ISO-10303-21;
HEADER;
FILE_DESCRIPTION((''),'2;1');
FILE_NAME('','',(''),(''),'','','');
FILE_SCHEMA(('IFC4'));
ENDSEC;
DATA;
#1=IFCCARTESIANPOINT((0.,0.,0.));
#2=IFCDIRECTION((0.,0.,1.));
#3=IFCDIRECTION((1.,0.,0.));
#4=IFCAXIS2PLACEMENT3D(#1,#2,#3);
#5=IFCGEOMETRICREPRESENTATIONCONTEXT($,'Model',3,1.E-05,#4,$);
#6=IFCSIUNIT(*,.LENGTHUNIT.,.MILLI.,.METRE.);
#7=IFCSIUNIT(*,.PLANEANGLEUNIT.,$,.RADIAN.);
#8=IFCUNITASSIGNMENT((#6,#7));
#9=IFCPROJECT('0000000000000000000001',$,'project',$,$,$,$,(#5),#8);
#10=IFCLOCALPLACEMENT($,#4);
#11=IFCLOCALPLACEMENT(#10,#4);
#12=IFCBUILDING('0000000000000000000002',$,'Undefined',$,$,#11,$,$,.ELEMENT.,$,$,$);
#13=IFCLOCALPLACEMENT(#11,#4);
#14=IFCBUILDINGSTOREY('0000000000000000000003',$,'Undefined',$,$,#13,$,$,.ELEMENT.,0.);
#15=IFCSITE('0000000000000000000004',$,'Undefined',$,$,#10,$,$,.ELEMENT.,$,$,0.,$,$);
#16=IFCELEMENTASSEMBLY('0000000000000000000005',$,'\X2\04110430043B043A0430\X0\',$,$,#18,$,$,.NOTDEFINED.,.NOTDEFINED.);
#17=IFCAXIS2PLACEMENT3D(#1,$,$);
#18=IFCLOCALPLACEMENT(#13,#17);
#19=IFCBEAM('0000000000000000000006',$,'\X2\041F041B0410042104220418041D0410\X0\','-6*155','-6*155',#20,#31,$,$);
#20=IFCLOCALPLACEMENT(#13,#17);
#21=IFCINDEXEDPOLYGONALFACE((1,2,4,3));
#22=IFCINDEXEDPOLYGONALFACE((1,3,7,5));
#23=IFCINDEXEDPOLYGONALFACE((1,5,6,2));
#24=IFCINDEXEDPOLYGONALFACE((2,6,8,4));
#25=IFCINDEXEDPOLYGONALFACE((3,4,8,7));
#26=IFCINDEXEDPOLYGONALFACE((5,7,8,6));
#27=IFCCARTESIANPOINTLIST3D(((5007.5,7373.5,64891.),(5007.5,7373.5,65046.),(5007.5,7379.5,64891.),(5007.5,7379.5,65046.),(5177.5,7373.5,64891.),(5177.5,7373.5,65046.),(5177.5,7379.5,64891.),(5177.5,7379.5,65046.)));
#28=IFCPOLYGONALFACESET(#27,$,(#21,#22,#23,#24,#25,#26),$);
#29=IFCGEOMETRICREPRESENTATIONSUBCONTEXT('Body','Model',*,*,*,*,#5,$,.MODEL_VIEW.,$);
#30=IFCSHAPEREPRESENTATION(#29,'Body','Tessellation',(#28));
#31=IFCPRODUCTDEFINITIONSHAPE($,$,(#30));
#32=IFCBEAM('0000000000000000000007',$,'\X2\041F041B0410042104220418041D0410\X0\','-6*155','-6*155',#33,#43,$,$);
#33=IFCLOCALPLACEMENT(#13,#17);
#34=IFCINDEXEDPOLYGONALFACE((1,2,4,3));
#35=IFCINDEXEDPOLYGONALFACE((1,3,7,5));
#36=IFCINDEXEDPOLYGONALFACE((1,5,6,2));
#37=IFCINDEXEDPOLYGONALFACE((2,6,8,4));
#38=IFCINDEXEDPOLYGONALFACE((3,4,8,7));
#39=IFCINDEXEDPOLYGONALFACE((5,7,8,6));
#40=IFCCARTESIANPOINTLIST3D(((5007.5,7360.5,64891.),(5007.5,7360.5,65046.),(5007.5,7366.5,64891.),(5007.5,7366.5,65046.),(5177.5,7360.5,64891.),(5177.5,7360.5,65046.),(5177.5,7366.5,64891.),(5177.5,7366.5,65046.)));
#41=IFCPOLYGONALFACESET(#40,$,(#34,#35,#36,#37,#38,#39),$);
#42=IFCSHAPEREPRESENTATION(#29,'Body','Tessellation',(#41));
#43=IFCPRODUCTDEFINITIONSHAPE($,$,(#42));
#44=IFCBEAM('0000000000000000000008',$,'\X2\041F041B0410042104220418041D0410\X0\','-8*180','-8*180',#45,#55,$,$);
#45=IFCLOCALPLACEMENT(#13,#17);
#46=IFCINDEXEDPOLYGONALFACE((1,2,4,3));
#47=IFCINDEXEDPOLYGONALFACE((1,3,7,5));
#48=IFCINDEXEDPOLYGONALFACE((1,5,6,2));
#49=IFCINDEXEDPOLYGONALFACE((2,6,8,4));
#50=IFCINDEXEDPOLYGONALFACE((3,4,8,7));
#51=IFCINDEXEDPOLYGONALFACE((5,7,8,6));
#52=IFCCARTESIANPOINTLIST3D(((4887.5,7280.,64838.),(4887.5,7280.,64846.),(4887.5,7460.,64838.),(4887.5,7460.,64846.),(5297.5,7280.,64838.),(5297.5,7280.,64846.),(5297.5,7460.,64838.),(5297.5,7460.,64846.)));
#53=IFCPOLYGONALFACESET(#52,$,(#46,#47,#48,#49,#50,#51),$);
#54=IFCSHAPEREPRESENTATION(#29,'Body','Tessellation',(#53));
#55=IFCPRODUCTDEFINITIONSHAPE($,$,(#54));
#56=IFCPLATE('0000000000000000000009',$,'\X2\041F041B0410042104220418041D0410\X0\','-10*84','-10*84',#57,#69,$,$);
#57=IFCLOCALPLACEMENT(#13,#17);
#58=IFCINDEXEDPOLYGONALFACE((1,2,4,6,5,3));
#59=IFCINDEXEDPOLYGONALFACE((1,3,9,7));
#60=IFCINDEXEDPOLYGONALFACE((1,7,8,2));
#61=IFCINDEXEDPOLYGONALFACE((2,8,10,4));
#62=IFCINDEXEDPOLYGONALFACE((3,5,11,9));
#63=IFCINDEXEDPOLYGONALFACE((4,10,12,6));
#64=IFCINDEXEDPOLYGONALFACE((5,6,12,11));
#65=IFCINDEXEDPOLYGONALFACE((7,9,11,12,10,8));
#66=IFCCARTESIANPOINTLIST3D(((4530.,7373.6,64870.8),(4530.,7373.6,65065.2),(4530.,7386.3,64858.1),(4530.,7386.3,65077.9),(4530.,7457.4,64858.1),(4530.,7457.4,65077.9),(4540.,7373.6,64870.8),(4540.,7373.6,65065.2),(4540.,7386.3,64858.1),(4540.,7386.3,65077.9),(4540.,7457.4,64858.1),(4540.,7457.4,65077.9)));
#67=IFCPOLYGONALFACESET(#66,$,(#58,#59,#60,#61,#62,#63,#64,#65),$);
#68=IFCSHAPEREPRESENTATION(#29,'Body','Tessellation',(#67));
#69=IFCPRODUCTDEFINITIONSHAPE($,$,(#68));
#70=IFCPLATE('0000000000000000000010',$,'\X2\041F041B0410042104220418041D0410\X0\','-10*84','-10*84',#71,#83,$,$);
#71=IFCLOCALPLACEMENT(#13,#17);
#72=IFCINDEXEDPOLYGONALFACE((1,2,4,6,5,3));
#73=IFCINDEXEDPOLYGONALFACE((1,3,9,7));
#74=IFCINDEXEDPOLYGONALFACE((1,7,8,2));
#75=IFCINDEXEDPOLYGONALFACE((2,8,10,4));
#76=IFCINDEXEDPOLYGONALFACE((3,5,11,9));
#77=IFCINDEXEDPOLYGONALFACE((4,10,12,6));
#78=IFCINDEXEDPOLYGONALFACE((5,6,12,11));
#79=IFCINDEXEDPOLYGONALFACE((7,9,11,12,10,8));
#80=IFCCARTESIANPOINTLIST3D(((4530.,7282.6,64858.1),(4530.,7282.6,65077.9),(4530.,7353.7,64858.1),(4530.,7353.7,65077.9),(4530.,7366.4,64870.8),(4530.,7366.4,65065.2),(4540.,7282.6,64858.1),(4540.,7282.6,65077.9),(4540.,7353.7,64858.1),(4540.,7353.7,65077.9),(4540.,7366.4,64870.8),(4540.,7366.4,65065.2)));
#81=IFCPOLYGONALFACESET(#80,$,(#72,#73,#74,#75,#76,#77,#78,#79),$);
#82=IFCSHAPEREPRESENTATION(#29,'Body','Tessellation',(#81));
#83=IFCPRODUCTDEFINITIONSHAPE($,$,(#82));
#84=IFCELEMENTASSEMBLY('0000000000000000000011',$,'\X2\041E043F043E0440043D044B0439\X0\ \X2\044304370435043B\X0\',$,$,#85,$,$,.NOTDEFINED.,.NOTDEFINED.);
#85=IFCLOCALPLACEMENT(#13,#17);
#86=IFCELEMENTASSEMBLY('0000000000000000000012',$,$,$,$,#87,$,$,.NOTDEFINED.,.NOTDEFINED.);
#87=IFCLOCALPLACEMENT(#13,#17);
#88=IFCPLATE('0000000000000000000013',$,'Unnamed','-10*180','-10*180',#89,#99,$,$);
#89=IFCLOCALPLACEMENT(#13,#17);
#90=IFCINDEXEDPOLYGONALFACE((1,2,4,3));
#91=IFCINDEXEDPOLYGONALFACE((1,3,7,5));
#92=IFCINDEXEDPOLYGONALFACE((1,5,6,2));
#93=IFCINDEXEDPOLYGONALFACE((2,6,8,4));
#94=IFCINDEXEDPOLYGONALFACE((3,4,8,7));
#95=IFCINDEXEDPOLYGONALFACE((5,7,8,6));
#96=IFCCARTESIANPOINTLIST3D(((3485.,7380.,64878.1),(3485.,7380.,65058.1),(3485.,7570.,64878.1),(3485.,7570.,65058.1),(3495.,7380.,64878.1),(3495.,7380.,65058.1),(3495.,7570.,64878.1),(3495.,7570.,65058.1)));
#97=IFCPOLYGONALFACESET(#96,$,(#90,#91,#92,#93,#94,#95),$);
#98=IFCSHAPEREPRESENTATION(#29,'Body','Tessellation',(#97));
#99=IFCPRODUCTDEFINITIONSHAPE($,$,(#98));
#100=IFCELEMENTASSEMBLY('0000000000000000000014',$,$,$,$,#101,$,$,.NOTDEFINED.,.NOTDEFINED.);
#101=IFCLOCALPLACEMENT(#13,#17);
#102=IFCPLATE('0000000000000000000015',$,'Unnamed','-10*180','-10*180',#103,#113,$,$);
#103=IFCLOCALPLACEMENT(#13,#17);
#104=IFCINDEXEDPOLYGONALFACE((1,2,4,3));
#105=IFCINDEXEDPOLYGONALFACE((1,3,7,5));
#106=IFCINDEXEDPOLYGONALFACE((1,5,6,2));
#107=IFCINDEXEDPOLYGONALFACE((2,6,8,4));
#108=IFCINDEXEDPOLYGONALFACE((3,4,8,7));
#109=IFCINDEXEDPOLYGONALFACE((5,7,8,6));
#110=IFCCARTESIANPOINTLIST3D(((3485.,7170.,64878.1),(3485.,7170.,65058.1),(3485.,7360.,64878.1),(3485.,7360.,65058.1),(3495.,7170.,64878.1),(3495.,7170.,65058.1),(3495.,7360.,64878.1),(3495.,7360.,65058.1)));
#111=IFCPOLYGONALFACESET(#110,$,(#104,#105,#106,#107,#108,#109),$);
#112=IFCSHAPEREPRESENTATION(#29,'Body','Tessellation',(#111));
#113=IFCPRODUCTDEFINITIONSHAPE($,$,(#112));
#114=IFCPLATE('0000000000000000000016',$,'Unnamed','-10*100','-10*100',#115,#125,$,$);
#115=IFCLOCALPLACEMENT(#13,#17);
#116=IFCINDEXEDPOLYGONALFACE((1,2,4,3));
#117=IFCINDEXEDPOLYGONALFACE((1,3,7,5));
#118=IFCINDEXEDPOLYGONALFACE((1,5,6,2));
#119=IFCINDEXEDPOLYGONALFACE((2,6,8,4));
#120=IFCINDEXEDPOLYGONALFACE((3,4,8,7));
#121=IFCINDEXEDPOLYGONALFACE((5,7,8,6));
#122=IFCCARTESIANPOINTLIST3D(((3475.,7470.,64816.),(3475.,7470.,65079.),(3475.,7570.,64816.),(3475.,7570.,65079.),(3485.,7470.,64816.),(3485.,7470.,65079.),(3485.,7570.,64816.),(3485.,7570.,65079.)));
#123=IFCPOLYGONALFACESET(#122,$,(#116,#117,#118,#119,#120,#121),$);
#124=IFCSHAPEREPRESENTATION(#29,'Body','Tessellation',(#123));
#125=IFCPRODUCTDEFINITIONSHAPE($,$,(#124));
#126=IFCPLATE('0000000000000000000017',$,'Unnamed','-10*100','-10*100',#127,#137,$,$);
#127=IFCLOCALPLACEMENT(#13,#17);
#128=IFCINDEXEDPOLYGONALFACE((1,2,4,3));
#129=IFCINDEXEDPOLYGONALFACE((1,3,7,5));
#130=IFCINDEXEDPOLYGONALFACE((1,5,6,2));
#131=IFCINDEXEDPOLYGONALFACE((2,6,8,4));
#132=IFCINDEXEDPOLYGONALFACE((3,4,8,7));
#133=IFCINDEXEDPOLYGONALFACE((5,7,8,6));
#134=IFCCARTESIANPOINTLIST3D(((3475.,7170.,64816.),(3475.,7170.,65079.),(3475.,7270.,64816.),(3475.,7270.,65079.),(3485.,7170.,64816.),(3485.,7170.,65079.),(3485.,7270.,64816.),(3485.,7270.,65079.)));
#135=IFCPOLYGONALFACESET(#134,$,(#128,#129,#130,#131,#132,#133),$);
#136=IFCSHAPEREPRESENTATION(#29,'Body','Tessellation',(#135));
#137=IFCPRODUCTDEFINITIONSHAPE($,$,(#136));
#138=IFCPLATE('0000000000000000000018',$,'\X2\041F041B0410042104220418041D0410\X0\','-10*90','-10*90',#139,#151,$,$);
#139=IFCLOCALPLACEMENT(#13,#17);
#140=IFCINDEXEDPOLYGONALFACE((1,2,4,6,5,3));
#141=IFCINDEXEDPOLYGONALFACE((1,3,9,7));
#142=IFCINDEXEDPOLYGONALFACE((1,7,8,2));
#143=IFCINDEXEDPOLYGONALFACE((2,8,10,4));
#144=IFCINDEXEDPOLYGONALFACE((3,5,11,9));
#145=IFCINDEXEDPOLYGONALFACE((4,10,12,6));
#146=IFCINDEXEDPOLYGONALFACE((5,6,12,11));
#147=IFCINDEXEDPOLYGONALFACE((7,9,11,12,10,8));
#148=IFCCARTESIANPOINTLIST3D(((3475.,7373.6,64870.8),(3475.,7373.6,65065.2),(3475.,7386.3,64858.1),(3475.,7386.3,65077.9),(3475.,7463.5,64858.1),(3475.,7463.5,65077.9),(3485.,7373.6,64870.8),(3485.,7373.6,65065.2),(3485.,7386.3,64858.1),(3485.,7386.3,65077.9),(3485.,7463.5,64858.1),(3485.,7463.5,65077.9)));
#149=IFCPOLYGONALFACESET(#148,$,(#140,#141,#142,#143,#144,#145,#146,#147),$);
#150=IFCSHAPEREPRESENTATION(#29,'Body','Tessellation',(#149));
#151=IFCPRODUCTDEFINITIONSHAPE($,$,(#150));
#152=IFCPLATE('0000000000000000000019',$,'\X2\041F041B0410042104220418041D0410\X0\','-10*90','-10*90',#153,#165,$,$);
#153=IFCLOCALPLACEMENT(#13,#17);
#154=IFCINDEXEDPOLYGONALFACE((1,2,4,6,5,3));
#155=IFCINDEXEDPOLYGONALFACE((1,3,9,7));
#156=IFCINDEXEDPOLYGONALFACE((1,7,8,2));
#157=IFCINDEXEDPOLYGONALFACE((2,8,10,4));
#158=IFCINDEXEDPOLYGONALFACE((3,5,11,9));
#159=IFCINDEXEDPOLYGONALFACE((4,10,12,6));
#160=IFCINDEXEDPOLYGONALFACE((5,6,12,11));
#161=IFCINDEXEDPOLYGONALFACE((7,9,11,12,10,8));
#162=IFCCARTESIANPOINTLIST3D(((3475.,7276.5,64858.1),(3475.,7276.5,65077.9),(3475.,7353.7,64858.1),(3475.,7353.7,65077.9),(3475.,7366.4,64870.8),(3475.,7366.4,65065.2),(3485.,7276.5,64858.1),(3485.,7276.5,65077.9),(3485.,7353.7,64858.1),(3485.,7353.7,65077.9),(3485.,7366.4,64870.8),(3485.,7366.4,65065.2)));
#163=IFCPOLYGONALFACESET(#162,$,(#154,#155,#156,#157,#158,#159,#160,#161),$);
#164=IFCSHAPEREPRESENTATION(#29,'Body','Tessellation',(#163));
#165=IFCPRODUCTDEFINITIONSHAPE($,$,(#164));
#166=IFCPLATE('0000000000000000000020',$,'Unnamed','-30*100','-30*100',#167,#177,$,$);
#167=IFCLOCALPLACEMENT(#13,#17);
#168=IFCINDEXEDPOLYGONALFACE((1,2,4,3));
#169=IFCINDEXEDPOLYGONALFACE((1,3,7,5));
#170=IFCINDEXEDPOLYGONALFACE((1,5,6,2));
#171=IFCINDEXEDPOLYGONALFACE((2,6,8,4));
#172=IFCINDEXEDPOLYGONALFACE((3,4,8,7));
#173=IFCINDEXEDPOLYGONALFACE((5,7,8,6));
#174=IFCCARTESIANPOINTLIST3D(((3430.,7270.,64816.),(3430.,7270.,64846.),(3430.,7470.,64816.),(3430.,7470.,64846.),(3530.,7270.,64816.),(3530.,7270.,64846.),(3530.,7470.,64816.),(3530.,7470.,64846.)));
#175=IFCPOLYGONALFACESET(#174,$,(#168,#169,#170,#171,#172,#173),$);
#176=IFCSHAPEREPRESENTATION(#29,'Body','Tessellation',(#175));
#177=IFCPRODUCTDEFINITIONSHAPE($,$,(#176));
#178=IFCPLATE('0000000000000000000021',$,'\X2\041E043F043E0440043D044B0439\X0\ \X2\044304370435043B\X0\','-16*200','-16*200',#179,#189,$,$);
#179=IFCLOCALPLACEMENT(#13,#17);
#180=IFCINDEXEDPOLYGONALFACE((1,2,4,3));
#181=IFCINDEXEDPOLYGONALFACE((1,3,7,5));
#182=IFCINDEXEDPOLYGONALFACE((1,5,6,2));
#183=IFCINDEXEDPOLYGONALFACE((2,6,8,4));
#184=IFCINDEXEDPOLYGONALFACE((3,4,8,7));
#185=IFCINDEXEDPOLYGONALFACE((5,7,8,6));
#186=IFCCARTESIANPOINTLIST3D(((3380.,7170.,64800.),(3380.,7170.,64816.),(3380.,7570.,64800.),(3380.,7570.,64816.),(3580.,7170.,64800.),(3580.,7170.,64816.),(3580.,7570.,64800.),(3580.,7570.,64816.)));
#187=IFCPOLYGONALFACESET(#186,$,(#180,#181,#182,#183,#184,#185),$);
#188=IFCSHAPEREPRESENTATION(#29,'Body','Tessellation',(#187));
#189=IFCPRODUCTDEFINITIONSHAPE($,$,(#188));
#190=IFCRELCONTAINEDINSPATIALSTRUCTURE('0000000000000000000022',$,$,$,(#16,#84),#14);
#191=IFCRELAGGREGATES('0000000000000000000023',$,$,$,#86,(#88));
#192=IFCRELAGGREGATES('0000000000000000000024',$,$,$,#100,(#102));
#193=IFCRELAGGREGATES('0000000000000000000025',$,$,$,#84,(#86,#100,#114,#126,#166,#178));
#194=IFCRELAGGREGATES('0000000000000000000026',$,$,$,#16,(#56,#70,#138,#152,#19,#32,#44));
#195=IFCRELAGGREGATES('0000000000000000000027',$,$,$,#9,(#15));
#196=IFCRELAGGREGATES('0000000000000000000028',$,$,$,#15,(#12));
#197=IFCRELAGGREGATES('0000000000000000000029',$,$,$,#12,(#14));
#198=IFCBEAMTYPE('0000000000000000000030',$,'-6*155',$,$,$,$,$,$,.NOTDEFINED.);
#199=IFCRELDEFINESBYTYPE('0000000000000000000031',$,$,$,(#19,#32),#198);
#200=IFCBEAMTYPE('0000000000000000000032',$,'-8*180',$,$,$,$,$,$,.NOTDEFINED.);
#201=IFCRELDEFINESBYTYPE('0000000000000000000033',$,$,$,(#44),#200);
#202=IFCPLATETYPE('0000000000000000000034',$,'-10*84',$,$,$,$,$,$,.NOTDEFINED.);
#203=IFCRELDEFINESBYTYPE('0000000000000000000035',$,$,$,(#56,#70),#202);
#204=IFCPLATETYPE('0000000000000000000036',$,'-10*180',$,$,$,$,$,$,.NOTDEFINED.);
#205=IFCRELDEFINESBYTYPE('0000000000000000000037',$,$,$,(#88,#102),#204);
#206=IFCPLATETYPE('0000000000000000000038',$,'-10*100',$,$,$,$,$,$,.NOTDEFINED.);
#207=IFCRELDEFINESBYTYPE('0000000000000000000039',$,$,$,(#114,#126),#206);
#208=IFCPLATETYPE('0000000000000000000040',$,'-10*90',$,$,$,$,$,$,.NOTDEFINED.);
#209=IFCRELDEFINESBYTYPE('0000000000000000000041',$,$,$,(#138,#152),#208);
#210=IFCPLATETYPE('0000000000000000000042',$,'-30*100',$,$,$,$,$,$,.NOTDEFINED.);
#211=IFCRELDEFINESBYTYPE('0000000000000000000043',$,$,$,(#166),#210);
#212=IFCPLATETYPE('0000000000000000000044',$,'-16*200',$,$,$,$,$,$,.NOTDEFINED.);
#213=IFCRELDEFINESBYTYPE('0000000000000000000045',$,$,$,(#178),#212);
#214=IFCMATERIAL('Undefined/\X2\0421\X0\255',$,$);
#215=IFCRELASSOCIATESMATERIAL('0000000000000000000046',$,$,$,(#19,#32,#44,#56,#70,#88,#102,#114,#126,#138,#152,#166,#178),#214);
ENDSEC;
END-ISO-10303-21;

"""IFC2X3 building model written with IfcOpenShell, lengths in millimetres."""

from ifc_helpers import new_model, si_unit, frame, origin_with_axes, origin_2d_with_axis, place, context, subcontext, project, spatial, polyline, rectangle, outline, extrude, material, type_object, element, aggregate, save


model = new_model("IFC2X3")

# Units and contexts
model_context = context("Model", 3, precision=1e-05, world=origin_with_axes())
body_context = subcontext(model_context, "Body", "Model", "MODEL_VIEW")
ifc_project = project(units=[si_unit("LENGTHUNIT", "METRE", prefix="MILLI"), si_unit("PLANEANGLEUNIT", "RADIAN")], contexts=[model_context])

# Site, building, storey
site_placement = place(None, origin_with_axes())
site = spatial("IfcSite", under=ifc_project, at=site_placement, Name="Undefined", CompositionType="ELEMENT", RefElevation=0.0)
building_placement = place(site_placement, origin_with_axes())
building = spatial("IfcBuilding", under=site, at=building_placement, Name="Undefined", CompositionType="ELEMENT")
storey_placement = place(building_placement, origin_with_axes())
storey = spatial("IfcBuildingStorey", under=building, at=storey_placement, Name="Undefined", CompositionType="ELEMENT", Elevation=0.0)

# Element assembly, beams, plates
assembly_1_placement = place(storey_placement, origin_with_axes())
assembly_1 = element("IfcElementAssembly", 1, at=assembly_1_placement, inside=storey, Name="Балка", AssemblyPlace="NOTDEFINED", PredefinedType="NOTDEFINED")
ifc_material_1 = material(Name="Undefined/С255")
beam_type_1 = type_object("IfcBeamType", Name="-6*155", PredefinedType="NOTDEFINED")
beam_1_placement = place(assembly_1_placement, frame((5007.5, 7376.5, 64968.5), z_axis=(0.0, 0.0, 1.0), x_axis=(1.0, 0.0, 0.0)))
beam_1 = element("IfcBeam", 2, at=beam_1_placement, type_object=beam_type_1, material=ifc_material_1, Name="ПЛАСТИНА", Description="-6*155", ObjectType="-6*155", context=body_context, shape_type="SweptSolid", body=[
    extrude(rectangle(XDim=6.0, YDim=155.0, at=origin_2d_with_axis()), frame((170.0, 0.0, 0.0), z_axis=(-1.0, 0.0, 0.0), x_axis=(0.0, -1.0, 0.0)), (0.0, 0.0, 1.0), 170.0),
])
beam_2_placement = place(assembly_1_placement, frame((5007.5, 7363.5, 64968.5), z_axis=(0.0, 0.0, 1.0), x_axis=(1.0, 0.0, 0.0)))
beam_2 = element("IfcBeam", 3, at=beam_2_placement, type_object=beam_type_1, material=ifc_material_1, Name="ПЛАСТИНА", Description="-6*155", ObjectType="-6*155", context=body_context, shape_type="SweptSolid", body=[
    extrude(rectangle(XDim=6.0, YDim=155.0, at=origin_2d_with_axis()), frame((170.0, 0.0, 0.0), z_axis=(-1.0, 0.0, 0.0), x_axis=(0.0, -1.0, 0.0)), (0.0, 0.0, 1.0), 170.0),
])
beam_type_2 = type_object("IfcBeamType", Name="-8*180", PredefinedType="NOTDEFINED")
beam_3_placement = place(assembly_1_placement, frame((4887.5, 7370.0, 64842.0), z_axis=(0.0, -1.0, 0.0), x_axis=(1.0, 0.0, 0.0)))
beam_3 = element("IfcBeam", 4, at=beam_3_placement, type_object=beam_type_2, material=ifc_material_1, Name="ПЛАСТИНА", Description="-8*180", ObjectType="-8*180", context=body_context, shape_type="SweptSolid", body=[
    extrude(rectangle(XDim=8.0, YDim=180.0, at=origin_2d_with_axis()), frame((410.0, 0.0, 0.0), z_axis=(-1.0, 0.0, 0.0), x_axis=(0.0, -1.0, 0.0)), (0.0, 0.0, 1.0), 410.0),
])
plate_type_1 = type_object("IfcPlateType", Name="-10*84", PredefinedType="NOTDEFINED")
plate_1_placement = place(assembly_1_placement, frame((4535.0, 7373.6, 65077.9), z_axis=(-1.0, 0.0, 0.0), x_axis=(0.0, 1.0, 0.0)))
plate_1 = element("IfcPlate", 5, at=plate_1_placement, type_object=plate_type_1, material=ifc_material_1, Name="ПЛАСТИНА", Description="-10*84", ObjectType="-10*84", context=body_context, shape_type="SweptSolid", body=[
    extrude(outline(polyline([(0.0, 12.7), (12.7, 0.0), (83.8, 0.0), (83.8, 219.8), (12.7, 219.8), (0.0, 207.1), (0.0, 12.7)])), frame((0.0, 0.0, -5.0), z_axis=(0.0, 0.0, 1.0), x_axis=(1.0, 0.0, 0.0)), (0.0, 0.0, 1.0), 10.0),
])
plate_2_placement = place(assembly_1_placement, frame((4535.0, 7282.6, 65077.9), z_axis=(-1.0, 0.0, 0.0), x_axis=(0.0, 1.0, 0.0)))
plate_2 = element("IfcPlate", 6, at=plate_2_placement, type_object=plate_type_1, material=ifc_material_1, Name="ПЛАСТИНА", Description="-10*84", ObjectType="-10*84", context=body_context, shape_type="SweptSolid", body=[
    extrude(outline(polyline([(0.0, 0.0), (71.1, 0.0), (83.8, 12.7), (83.8, 207.1), (71.1, 219.8), (0.0, 219.8), (0.0, 0.0)])), frame((0.0, 0.0, -5.0), z_axis=(0.0, 0.0, 1.0), x_axis=(1.0, 0.0, 0.0)), (0.0, 0.0, 1.0), 10.0),
])

# Element assemblies, plates
assembly_2_placement = place(storey_placement, origin_with_axes())
assembly_2 = element("IfcElementAssembly", 7, at=assembly_2_placement, inside=storey, Name="Опорный узел", AssemblyPlace="NOTDEFINED", PredefinedType="NOTDEFINED")
assembly_3_placement = place(assembly_2_placement, origin_with_axes())
assembly_3 = element("IfcElementAssembly", 8, at=assembly_3_placement, AssemblyPlace="NOTDEFINED", PredefinedType="NOTDEFINED")
plate_type_2 = type_object("IfcPlateType", Name="-10*180", PredefinedType="NOTDEFINED")
plate_3_placement = place(assembly_3_placement, frame((3490.0, 7570.0, 65058.1), z_axis=(1.0, 0.0, 0.0), x_axis=(0.0, -1.0, 0.0)))
plate_3 = element("IfcPlate", 9, at=plate_3_placement, type_object=plate_type_2, material=ifc_material_1, Name="Unnamed", Description="-10*180", ObjectType="-10*180", context=body_context, shape_type="SweptSolid", body=[
    extrude(outline(polyline([(0.0, 0.0), (190.0, 0.0), (190.0, 180.0), (0.0, 180.0), (0.0, 0.0)])), frame((0.0, 0.0, -5.0), z_axis=(0.0, 0.0, 1.0), x_axis=(1.0, 0.0, 0.0)), (0.0, 0.0, 1.0), 10.0),
])
aggregate(assembly_3, [plate_3])
assembly_4_placement = place(assembly_2_placement, origin_with_axes())
assembly_4 = element("IfcElementAssembly", 10, at=assembly_4_placement, AssemblyPlace="NOTDEFINED", PredefinedType="NOTDEFINED")
plate_4_placement = place(assembly_4_placement, frame((3490.0, 7360.0, 65058.1), z_axis=(1.0, 0.0, 0.0), x_axis=(0.0, -1.0, 0.0)))
plate_4 = element("IfcPlate", 11, at=plate_4_placement, type_object=plate_type_2, material=ifc_material_1, Name="Unnamed", Description="-10*180", ObjectType="-10*180", context=body_context, shape_type="SweptSolid", body=[
    extrude(outline(polyline([(0.0, 0.0), (190.0, 0.0), (190.0, 180.0), (0.0, 180.0), (0.0, 0.0)])), frame((0.0, 0.0, -5.0), z_axis=(0.0, 0.0, 1.0), x_axis=(1.0, 0.0, 0.0)), (0.0, 0.0, 1.0), 10.0),
])
aggregate(assembly_4, [plate_4])
plate_type_3 = type_object("IfcPlateType", Name="-10*100", PredefinedType="NOTDEFINED")
plate_5_placement = place(assembly_2_placement, frame((3480.0, 7470.0, 64816.0), z_axis=(-1.0, 0.0, 0.0), x_axis=(0.0, 0.0, 1.0)))
plate_5 = element("IfcPlate", 12, at=plate_5_placement, type_object=plate_type_3, material=ifc_material_1, Name="Unnamed", Description="-10*100", ObjectType="-10*100", context=body_context, shape_type="SweptSolid", body=[
    extrude(outline(polyline([(0.0, 0.0), (263.0, 0.0), (263.0, 100.0), (0.0, 100.0), (0.0, 0.0)])), frame((0.0, 0.0, -5.0), z_axis=(0.0, 0.0, 1.0), x_axis=(1.0, 0.0, 0.0)), (0.0, 0.0, 1.0), 10.0),
])
plate_6_placement = place(assembly_2_placement, frame((3480.0, 7170.0, 64816.0), z_axis=(-1.0, 0.0, 0.0), x_axis=(0.0, 0.0, 1.0)))
plate_6 = element("IfcPlate", 13, at=plate_6_placement, type_object=plate_type_3, material=ifc_material_1, Name="Unnamed", Description="-10*100", ObjectType="-10*100", context=body_context, shape_type="SweptSolid", body=[
    extrude(outline(polyline([(0.0, 0.0), (263.0, 0.0), (263.0, 100.0), (0.0, 100.0), (0.0, 0.0)])), frame((0.0, 0.0, -5.0), z_axis=(0.0, 0.0, 1.0), x_axis=(1.0, 0.0, 0.0)), (0.0, 0.0, 1.0), 10.0),
])

# Plates
plate_type_4 = type_object("IfcPlateType", Name="-10*90", PredefinedType="NOTDEFINED")
plate_7_placement = place(assembly_1_placement, frame((3480.0, 7373.6, 65077.9), z_axis=(-1.0, 0.0, 0.0), x_axis=(0.0, 1.0, 0.0)))
plate_7 = element("IfcPlate", 14, at=plate_7_placement, type_object=plate_type_4, material=ifc_material_1, Name="ПЛАСТИНА", Description="-10*90", ObjectType="-10*90", context=body_context, shape_type="SweptSolid", body=[
    extrude(outline(polyline([(0.0, 12.7), (12.7, 0.0), (89.9, 0.0), (89.9, 219.8), (12.7, 219.8), (0.0, 207.1), (0.0, 12.7)])), frame((0.0, 0.0, -5.0), z_axis=(0.0, 0.0, 1.0), x_axis=(1.0, 0.0, 0.0)), (0.0, 0.0, 1.0), 10.0),
])
plate_8_placement = place(assembly_1_placement, frame((3480.0, 7276.5, 65077.9), z_axis=(-1.0, 0.0, 0.0), x_axis=(0.0, 1.0, 0.0)))
plate_8 = element("IfcPlate", 15, at=plate_8_placement, type_object=plate_type_4, material=ifc_material_1, Name="ПЛАСТИНА", Description="-10*90", ObjectType="-10*90", context=body_context, shape_type="SweptSolid", body=[
    extrude(outline(polyline([(0.0, 0.0), (77.2, 0.0), (89.9, 12.7), (89.9, 207.1), (77.2, 219.8), (0.0, 219.8), (0.0, 0.0)])), frame((0.0, 0.0, -5.0), z_axis=(0.0, 0.0, 1.0), x_axis=(1.0, 0.0, 0.0)), (0.0, 0.0, 1.0), 10.0),
])
plate_type_5 = type_object("IfcPlateType", Name="-30*100", PredefinedType="NOTDEFINED")
plate_9_placement = place(assembly_2_placement, frame((3430.0, 7470.0, 64831.0), z_axis=(0.0, 0.0, 1.0), x_axis=(0.0, -1.0, 0.0)))
plate_9 = element("IfcPlate", 16, at=plate_9_placement, type_object=plate_type_5, material=ifc_material_1, Name="Unnamed", Description="-30*100", ObjectType="-30*100", context=body_context, shape_type="SweptSolid", body=[
    extrude(outline(polyline([(0.0, 0.0), (200.0, 0.0), (200.0, 100.0), (0.0, 100.0), (0.0, 0.0)])), frame((0.0, 0.0, -15.0), z_axis=(0.0, 0.0, 1.0), x_axis=(1.0, 0.0, 0.0)), (0.0, 0.0, 1.0), 30.0),
])
plate_type_6 = type_object("IfcPlateType", Name="-16*200", PredefinedType="NOTDEFINED")
plate_10_placement = place(assembly_2_placement, frame((3380.0, 7570.0, 64808.0), z_axis=(0.0, 0.0, 1.0), x_axis=(0.0, -1.0, 0.0)))
plate_10 = element("IfcPlate", 17, at=plate_10_placement, type_object=plate_type_6, material=ifc_material_1, Name="Опорный узел", Description="-16*200", ObjectType="-16*200", context=body_context, shape_type="SweptSolid", body=[
    extrude(outline(polyline([(0.0, 0.0), (400.0, 0.0), (400.0, 200.0), (0.0, 200.0), (0.0, 0.0)])), frame((0.0, 0.0, -8.0), z_axis=(0.0, 0.0, 1.0), x_axis=(1.0, 0.0, 0.0)), (0.0, 0.0, 1.0), 16.0),
])

aggregate(assembly_2, [assembly_3, assembly_4, plate_5, plate_6, plate_9, plate_10])

aggregate(assembly_1, [plate_1, plate_2, plate_7, plate_8, beam_1, beam_2, beam_3])

save(model, "model.ifc")
